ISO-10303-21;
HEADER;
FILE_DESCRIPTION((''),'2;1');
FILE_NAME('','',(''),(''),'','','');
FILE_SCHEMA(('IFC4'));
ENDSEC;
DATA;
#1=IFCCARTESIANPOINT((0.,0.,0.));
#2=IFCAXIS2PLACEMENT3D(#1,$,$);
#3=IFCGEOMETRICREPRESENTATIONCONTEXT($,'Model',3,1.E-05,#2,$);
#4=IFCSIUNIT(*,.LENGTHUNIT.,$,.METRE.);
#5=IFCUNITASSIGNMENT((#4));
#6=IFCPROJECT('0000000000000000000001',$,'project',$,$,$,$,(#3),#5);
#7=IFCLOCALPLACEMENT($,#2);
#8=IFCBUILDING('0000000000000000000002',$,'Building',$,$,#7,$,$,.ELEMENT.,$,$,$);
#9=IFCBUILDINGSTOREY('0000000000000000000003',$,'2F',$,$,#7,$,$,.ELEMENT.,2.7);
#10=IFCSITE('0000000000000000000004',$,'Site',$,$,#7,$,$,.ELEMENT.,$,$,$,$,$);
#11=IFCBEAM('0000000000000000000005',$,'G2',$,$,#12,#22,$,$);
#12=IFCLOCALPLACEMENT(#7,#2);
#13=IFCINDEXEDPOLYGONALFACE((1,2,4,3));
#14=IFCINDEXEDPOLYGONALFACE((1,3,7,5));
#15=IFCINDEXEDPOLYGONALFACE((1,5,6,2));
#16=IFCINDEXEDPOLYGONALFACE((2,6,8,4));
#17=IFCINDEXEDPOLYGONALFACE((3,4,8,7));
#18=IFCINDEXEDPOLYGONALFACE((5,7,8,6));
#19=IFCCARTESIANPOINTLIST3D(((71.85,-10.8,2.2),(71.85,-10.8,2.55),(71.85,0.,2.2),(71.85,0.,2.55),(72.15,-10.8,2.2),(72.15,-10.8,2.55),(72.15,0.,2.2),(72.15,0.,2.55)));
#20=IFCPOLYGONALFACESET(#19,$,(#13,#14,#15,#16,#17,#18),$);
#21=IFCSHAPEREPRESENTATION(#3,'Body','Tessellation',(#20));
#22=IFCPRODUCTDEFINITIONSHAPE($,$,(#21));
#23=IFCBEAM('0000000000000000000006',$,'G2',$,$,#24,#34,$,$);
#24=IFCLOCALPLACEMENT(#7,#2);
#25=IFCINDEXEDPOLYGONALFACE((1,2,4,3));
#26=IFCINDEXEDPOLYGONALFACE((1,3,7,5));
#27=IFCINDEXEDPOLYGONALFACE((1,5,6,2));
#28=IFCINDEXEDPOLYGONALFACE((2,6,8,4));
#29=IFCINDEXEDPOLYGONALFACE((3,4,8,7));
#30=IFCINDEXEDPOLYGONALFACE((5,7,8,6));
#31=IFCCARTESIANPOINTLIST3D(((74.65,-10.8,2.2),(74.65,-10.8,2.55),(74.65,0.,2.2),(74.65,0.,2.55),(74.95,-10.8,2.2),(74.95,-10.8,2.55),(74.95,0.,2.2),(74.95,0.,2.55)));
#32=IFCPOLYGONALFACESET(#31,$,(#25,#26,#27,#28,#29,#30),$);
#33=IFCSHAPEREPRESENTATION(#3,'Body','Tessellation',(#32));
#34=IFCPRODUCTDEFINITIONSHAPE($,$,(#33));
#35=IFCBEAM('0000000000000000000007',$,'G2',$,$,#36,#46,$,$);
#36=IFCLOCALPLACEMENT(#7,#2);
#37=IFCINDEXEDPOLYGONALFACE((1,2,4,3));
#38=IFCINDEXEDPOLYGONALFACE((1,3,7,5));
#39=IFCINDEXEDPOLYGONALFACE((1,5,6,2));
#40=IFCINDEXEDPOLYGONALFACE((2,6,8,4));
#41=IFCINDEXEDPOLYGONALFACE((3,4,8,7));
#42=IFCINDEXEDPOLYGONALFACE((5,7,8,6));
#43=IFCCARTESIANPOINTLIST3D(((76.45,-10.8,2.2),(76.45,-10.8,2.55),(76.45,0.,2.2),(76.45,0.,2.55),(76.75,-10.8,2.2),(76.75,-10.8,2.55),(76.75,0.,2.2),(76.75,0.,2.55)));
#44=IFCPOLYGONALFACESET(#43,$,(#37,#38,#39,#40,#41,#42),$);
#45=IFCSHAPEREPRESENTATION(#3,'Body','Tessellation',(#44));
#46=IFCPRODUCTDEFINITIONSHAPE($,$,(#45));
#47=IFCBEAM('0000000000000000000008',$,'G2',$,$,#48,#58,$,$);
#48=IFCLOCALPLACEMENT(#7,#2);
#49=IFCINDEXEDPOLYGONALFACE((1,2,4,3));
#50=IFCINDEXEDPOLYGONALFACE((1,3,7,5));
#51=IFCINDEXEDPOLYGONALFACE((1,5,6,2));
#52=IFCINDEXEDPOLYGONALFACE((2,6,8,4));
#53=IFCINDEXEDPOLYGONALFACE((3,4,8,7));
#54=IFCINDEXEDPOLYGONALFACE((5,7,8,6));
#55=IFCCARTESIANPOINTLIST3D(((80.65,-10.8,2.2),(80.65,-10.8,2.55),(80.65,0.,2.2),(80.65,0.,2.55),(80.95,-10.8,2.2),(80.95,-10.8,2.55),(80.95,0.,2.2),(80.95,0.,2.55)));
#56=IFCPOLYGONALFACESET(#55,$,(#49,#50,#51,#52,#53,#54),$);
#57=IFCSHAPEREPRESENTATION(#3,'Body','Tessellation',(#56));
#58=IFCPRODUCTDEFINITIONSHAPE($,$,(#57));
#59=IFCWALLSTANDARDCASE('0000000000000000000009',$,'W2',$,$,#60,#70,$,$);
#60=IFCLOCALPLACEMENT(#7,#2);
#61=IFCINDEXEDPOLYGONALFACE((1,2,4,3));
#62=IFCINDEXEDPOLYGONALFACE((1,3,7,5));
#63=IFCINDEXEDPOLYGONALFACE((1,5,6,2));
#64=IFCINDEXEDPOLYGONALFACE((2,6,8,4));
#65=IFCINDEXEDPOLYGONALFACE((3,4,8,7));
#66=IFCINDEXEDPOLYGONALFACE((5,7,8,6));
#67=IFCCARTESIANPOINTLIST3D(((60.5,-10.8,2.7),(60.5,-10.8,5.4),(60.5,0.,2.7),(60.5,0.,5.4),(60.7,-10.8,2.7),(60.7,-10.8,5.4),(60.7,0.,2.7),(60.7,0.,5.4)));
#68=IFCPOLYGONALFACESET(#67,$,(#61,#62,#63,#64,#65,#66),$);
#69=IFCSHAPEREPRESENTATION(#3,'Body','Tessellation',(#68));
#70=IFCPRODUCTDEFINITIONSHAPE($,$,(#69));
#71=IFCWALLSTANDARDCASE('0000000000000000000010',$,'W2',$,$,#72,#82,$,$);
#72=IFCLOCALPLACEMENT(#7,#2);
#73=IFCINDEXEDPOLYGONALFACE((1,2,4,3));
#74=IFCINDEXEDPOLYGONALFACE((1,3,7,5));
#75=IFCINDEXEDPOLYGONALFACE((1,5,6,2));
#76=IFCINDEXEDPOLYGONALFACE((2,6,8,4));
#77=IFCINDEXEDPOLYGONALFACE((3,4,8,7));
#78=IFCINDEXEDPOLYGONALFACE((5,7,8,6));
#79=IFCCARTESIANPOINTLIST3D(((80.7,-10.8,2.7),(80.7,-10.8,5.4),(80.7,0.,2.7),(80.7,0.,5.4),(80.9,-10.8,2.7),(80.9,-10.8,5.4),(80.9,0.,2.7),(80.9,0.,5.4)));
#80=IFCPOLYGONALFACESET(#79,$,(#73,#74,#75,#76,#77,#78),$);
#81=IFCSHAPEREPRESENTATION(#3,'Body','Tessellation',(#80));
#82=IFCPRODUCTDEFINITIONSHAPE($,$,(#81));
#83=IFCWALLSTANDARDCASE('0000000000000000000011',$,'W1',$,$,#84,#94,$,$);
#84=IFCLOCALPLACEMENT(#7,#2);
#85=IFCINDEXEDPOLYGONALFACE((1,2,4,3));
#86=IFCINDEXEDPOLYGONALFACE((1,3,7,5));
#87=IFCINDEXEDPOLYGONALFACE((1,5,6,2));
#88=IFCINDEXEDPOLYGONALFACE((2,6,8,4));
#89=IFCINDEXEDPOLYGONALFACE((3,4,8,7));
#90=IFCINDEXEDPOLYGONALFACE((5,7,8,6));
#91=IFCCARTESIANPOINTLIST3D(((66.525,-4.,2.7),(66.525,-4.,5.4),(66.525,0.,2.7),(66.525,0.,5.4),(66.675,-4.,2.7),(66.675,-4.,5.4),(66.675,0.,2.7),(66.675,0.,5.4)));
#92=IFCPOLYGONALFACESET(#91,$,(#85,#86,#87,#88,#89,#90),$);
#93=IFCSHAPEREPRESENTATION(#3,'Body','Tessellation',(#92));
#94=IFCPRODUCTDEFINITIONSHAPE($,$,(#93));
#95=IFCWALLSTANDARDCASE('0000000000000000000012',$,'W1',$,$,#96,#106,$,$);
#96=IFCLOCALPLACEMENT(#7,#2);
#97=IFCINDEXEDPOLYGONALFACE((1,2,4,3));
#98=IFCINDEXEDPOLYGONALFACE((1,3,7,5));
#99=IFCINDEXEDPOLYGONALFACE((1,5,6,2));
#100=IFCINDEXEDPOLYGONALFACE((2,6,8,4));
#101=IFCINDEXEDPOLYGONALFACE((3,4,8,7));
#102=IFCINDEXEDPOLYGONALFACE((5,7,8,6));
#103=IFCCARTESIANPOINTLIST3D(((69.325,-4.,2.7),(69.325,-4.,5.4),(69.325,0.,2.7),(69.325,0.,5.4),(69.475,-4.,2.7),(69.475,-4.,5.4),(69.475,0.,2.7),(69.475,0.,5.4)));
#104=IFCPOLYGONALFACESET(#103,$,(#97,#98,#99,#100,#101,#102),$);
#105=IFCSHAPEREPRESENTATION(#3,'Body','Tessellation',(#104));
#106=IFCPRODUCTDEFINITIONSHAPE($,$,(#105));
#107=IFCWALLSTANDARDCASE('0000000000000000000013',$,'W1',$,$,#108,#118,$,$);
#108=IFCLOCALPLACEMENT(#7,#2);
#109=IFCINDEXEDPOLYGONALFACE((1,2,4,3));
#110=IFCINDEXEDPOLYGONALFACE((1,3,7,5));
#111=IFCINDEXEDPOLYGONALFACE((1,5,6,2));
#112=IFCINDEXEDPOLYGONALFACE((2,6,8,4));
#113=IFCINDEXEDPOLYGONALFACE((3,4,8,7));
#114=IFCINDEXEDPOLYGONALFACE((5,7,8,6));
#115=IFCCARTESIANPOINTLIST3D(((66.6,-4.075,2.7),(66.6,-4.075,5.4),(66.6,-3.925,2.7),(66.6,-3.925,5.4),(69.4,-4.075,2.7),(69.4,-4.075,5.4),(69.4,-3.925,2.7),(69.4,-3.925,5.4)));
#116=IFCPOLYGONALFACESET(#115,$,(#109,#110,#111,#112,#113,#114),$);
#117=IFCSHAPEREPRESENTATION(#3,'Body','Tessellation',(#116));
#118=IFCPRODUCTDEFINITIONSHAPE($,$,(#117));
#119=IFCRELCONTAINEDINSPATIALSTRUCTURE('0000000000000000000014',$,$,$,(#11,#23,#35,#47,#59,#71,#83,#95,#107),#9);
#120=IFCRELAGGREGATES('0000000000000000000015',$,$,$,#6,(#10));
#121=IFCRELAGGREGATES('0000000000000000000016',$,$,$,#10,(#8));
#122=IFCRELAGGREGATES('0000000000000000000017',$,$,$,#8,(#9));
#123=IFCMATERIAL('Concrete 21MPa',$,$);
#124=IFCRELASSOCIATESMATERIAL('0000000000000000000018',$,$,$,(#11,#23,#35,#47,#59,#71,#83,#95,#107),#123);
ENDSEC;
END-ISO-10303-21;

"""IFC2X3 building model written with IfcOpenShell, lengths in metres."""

from ifc_helpers import new_model, si_unit, frame, origin, origin_2d, place, context, project, spatial, rectangle, extrude, material, element, save


model = new_model("IFC2X3")

# Units and contexts
model_context = context("Model", 3, precision=1e-05, world=origin())
ifc_project = project(units=[si_unit("LENGTHUNIT", "METRE")], contexts=[model_context])

# Site, building, storey
placement = place(None, origin())
site = spatial("IfcSite", under=ifc_project, at=placement, Name="Site", CompositionType="ELEMENT")
building = spatial("IfcBuilding", under=site, at=placement, Name="Building", CompositionType="ELEMENT")
storey = spatial("IfcBuildingStorey", under=building, at=placement, Name="2F", CompositionType="ELEMENT", Elevation=2.7)

# Shared definitions
ifc_material = material(Name="Concrete 21MPa")

# Beams
for number, where, name in (
    (1, (72.0, -5.4, 2.2), "G2"),
    (2, (74.8, -5.4, 2.2), "G2"),
    (3, (76.6, -5.4, 2.2), "G2"),
    (4, (80.8, -5.4, 2.2), "G2"),
):
    element("IfcBeam", number, at=place(None, frame(where)), inside=storey, material=ifc_material, Name=name, context=model_context, shape_type="SweptSolid", body=[
        extrude(rectangle(XDim=0.3, YDim=10.8, at=origin_2d()), origin(), (0.0, 0.0, 1.0), 0.35),
    ])

# Walls
for number, where, name in (
    (5, (60.6, -5.4, 2.7), "W2"),
    (6, (80.8, -5.4, 2.7), "W2"),
):
    element("IfcWallStandardCase", number, at=place(None, frame(where)), inside=storey, material=ifc_material, Name=name, context=model_context, shape_type="SweptSolid", body=[
        extrude(rectangle(XDim=0.2, YDim=10.8, at=origin_2d()), origin(), (0.0, 0.0, 1.0), 2.7),
    ])
for number, where, name in (
    (7, (66.6, -2.0, 2.7), "W1"),
    (8, (69.4, -2.0, 2.7), "W1"),
):
    element("IfcWallStandardCase", number, at=place(None, frame(where)), inside=storey, material=ifc_material, Name=name, context=model_context, shape_type="SweptSolid", body=[
        extrude(rectangle(XDim=0.15, YDim=4.0, at=origin_2d()), origin(), (0.0, 0.0, 1.0), 2.7),
    ])
wall_placement = place(None, frame((68.0, -4.0, 2.7)))
element("IfcWallStandardCase", 9, at=wall_placement, inside=storey, material=ifc_material, Name="W1", context=model_context, shape_type="SweptSolid", body=[
    extrude(rectangle(XDim=2.8, YDim=0.15, at=origin_2d()), origin(), (0.0, 0.0, 1.0), 2.7),
])

save(model, "model.ifc")
